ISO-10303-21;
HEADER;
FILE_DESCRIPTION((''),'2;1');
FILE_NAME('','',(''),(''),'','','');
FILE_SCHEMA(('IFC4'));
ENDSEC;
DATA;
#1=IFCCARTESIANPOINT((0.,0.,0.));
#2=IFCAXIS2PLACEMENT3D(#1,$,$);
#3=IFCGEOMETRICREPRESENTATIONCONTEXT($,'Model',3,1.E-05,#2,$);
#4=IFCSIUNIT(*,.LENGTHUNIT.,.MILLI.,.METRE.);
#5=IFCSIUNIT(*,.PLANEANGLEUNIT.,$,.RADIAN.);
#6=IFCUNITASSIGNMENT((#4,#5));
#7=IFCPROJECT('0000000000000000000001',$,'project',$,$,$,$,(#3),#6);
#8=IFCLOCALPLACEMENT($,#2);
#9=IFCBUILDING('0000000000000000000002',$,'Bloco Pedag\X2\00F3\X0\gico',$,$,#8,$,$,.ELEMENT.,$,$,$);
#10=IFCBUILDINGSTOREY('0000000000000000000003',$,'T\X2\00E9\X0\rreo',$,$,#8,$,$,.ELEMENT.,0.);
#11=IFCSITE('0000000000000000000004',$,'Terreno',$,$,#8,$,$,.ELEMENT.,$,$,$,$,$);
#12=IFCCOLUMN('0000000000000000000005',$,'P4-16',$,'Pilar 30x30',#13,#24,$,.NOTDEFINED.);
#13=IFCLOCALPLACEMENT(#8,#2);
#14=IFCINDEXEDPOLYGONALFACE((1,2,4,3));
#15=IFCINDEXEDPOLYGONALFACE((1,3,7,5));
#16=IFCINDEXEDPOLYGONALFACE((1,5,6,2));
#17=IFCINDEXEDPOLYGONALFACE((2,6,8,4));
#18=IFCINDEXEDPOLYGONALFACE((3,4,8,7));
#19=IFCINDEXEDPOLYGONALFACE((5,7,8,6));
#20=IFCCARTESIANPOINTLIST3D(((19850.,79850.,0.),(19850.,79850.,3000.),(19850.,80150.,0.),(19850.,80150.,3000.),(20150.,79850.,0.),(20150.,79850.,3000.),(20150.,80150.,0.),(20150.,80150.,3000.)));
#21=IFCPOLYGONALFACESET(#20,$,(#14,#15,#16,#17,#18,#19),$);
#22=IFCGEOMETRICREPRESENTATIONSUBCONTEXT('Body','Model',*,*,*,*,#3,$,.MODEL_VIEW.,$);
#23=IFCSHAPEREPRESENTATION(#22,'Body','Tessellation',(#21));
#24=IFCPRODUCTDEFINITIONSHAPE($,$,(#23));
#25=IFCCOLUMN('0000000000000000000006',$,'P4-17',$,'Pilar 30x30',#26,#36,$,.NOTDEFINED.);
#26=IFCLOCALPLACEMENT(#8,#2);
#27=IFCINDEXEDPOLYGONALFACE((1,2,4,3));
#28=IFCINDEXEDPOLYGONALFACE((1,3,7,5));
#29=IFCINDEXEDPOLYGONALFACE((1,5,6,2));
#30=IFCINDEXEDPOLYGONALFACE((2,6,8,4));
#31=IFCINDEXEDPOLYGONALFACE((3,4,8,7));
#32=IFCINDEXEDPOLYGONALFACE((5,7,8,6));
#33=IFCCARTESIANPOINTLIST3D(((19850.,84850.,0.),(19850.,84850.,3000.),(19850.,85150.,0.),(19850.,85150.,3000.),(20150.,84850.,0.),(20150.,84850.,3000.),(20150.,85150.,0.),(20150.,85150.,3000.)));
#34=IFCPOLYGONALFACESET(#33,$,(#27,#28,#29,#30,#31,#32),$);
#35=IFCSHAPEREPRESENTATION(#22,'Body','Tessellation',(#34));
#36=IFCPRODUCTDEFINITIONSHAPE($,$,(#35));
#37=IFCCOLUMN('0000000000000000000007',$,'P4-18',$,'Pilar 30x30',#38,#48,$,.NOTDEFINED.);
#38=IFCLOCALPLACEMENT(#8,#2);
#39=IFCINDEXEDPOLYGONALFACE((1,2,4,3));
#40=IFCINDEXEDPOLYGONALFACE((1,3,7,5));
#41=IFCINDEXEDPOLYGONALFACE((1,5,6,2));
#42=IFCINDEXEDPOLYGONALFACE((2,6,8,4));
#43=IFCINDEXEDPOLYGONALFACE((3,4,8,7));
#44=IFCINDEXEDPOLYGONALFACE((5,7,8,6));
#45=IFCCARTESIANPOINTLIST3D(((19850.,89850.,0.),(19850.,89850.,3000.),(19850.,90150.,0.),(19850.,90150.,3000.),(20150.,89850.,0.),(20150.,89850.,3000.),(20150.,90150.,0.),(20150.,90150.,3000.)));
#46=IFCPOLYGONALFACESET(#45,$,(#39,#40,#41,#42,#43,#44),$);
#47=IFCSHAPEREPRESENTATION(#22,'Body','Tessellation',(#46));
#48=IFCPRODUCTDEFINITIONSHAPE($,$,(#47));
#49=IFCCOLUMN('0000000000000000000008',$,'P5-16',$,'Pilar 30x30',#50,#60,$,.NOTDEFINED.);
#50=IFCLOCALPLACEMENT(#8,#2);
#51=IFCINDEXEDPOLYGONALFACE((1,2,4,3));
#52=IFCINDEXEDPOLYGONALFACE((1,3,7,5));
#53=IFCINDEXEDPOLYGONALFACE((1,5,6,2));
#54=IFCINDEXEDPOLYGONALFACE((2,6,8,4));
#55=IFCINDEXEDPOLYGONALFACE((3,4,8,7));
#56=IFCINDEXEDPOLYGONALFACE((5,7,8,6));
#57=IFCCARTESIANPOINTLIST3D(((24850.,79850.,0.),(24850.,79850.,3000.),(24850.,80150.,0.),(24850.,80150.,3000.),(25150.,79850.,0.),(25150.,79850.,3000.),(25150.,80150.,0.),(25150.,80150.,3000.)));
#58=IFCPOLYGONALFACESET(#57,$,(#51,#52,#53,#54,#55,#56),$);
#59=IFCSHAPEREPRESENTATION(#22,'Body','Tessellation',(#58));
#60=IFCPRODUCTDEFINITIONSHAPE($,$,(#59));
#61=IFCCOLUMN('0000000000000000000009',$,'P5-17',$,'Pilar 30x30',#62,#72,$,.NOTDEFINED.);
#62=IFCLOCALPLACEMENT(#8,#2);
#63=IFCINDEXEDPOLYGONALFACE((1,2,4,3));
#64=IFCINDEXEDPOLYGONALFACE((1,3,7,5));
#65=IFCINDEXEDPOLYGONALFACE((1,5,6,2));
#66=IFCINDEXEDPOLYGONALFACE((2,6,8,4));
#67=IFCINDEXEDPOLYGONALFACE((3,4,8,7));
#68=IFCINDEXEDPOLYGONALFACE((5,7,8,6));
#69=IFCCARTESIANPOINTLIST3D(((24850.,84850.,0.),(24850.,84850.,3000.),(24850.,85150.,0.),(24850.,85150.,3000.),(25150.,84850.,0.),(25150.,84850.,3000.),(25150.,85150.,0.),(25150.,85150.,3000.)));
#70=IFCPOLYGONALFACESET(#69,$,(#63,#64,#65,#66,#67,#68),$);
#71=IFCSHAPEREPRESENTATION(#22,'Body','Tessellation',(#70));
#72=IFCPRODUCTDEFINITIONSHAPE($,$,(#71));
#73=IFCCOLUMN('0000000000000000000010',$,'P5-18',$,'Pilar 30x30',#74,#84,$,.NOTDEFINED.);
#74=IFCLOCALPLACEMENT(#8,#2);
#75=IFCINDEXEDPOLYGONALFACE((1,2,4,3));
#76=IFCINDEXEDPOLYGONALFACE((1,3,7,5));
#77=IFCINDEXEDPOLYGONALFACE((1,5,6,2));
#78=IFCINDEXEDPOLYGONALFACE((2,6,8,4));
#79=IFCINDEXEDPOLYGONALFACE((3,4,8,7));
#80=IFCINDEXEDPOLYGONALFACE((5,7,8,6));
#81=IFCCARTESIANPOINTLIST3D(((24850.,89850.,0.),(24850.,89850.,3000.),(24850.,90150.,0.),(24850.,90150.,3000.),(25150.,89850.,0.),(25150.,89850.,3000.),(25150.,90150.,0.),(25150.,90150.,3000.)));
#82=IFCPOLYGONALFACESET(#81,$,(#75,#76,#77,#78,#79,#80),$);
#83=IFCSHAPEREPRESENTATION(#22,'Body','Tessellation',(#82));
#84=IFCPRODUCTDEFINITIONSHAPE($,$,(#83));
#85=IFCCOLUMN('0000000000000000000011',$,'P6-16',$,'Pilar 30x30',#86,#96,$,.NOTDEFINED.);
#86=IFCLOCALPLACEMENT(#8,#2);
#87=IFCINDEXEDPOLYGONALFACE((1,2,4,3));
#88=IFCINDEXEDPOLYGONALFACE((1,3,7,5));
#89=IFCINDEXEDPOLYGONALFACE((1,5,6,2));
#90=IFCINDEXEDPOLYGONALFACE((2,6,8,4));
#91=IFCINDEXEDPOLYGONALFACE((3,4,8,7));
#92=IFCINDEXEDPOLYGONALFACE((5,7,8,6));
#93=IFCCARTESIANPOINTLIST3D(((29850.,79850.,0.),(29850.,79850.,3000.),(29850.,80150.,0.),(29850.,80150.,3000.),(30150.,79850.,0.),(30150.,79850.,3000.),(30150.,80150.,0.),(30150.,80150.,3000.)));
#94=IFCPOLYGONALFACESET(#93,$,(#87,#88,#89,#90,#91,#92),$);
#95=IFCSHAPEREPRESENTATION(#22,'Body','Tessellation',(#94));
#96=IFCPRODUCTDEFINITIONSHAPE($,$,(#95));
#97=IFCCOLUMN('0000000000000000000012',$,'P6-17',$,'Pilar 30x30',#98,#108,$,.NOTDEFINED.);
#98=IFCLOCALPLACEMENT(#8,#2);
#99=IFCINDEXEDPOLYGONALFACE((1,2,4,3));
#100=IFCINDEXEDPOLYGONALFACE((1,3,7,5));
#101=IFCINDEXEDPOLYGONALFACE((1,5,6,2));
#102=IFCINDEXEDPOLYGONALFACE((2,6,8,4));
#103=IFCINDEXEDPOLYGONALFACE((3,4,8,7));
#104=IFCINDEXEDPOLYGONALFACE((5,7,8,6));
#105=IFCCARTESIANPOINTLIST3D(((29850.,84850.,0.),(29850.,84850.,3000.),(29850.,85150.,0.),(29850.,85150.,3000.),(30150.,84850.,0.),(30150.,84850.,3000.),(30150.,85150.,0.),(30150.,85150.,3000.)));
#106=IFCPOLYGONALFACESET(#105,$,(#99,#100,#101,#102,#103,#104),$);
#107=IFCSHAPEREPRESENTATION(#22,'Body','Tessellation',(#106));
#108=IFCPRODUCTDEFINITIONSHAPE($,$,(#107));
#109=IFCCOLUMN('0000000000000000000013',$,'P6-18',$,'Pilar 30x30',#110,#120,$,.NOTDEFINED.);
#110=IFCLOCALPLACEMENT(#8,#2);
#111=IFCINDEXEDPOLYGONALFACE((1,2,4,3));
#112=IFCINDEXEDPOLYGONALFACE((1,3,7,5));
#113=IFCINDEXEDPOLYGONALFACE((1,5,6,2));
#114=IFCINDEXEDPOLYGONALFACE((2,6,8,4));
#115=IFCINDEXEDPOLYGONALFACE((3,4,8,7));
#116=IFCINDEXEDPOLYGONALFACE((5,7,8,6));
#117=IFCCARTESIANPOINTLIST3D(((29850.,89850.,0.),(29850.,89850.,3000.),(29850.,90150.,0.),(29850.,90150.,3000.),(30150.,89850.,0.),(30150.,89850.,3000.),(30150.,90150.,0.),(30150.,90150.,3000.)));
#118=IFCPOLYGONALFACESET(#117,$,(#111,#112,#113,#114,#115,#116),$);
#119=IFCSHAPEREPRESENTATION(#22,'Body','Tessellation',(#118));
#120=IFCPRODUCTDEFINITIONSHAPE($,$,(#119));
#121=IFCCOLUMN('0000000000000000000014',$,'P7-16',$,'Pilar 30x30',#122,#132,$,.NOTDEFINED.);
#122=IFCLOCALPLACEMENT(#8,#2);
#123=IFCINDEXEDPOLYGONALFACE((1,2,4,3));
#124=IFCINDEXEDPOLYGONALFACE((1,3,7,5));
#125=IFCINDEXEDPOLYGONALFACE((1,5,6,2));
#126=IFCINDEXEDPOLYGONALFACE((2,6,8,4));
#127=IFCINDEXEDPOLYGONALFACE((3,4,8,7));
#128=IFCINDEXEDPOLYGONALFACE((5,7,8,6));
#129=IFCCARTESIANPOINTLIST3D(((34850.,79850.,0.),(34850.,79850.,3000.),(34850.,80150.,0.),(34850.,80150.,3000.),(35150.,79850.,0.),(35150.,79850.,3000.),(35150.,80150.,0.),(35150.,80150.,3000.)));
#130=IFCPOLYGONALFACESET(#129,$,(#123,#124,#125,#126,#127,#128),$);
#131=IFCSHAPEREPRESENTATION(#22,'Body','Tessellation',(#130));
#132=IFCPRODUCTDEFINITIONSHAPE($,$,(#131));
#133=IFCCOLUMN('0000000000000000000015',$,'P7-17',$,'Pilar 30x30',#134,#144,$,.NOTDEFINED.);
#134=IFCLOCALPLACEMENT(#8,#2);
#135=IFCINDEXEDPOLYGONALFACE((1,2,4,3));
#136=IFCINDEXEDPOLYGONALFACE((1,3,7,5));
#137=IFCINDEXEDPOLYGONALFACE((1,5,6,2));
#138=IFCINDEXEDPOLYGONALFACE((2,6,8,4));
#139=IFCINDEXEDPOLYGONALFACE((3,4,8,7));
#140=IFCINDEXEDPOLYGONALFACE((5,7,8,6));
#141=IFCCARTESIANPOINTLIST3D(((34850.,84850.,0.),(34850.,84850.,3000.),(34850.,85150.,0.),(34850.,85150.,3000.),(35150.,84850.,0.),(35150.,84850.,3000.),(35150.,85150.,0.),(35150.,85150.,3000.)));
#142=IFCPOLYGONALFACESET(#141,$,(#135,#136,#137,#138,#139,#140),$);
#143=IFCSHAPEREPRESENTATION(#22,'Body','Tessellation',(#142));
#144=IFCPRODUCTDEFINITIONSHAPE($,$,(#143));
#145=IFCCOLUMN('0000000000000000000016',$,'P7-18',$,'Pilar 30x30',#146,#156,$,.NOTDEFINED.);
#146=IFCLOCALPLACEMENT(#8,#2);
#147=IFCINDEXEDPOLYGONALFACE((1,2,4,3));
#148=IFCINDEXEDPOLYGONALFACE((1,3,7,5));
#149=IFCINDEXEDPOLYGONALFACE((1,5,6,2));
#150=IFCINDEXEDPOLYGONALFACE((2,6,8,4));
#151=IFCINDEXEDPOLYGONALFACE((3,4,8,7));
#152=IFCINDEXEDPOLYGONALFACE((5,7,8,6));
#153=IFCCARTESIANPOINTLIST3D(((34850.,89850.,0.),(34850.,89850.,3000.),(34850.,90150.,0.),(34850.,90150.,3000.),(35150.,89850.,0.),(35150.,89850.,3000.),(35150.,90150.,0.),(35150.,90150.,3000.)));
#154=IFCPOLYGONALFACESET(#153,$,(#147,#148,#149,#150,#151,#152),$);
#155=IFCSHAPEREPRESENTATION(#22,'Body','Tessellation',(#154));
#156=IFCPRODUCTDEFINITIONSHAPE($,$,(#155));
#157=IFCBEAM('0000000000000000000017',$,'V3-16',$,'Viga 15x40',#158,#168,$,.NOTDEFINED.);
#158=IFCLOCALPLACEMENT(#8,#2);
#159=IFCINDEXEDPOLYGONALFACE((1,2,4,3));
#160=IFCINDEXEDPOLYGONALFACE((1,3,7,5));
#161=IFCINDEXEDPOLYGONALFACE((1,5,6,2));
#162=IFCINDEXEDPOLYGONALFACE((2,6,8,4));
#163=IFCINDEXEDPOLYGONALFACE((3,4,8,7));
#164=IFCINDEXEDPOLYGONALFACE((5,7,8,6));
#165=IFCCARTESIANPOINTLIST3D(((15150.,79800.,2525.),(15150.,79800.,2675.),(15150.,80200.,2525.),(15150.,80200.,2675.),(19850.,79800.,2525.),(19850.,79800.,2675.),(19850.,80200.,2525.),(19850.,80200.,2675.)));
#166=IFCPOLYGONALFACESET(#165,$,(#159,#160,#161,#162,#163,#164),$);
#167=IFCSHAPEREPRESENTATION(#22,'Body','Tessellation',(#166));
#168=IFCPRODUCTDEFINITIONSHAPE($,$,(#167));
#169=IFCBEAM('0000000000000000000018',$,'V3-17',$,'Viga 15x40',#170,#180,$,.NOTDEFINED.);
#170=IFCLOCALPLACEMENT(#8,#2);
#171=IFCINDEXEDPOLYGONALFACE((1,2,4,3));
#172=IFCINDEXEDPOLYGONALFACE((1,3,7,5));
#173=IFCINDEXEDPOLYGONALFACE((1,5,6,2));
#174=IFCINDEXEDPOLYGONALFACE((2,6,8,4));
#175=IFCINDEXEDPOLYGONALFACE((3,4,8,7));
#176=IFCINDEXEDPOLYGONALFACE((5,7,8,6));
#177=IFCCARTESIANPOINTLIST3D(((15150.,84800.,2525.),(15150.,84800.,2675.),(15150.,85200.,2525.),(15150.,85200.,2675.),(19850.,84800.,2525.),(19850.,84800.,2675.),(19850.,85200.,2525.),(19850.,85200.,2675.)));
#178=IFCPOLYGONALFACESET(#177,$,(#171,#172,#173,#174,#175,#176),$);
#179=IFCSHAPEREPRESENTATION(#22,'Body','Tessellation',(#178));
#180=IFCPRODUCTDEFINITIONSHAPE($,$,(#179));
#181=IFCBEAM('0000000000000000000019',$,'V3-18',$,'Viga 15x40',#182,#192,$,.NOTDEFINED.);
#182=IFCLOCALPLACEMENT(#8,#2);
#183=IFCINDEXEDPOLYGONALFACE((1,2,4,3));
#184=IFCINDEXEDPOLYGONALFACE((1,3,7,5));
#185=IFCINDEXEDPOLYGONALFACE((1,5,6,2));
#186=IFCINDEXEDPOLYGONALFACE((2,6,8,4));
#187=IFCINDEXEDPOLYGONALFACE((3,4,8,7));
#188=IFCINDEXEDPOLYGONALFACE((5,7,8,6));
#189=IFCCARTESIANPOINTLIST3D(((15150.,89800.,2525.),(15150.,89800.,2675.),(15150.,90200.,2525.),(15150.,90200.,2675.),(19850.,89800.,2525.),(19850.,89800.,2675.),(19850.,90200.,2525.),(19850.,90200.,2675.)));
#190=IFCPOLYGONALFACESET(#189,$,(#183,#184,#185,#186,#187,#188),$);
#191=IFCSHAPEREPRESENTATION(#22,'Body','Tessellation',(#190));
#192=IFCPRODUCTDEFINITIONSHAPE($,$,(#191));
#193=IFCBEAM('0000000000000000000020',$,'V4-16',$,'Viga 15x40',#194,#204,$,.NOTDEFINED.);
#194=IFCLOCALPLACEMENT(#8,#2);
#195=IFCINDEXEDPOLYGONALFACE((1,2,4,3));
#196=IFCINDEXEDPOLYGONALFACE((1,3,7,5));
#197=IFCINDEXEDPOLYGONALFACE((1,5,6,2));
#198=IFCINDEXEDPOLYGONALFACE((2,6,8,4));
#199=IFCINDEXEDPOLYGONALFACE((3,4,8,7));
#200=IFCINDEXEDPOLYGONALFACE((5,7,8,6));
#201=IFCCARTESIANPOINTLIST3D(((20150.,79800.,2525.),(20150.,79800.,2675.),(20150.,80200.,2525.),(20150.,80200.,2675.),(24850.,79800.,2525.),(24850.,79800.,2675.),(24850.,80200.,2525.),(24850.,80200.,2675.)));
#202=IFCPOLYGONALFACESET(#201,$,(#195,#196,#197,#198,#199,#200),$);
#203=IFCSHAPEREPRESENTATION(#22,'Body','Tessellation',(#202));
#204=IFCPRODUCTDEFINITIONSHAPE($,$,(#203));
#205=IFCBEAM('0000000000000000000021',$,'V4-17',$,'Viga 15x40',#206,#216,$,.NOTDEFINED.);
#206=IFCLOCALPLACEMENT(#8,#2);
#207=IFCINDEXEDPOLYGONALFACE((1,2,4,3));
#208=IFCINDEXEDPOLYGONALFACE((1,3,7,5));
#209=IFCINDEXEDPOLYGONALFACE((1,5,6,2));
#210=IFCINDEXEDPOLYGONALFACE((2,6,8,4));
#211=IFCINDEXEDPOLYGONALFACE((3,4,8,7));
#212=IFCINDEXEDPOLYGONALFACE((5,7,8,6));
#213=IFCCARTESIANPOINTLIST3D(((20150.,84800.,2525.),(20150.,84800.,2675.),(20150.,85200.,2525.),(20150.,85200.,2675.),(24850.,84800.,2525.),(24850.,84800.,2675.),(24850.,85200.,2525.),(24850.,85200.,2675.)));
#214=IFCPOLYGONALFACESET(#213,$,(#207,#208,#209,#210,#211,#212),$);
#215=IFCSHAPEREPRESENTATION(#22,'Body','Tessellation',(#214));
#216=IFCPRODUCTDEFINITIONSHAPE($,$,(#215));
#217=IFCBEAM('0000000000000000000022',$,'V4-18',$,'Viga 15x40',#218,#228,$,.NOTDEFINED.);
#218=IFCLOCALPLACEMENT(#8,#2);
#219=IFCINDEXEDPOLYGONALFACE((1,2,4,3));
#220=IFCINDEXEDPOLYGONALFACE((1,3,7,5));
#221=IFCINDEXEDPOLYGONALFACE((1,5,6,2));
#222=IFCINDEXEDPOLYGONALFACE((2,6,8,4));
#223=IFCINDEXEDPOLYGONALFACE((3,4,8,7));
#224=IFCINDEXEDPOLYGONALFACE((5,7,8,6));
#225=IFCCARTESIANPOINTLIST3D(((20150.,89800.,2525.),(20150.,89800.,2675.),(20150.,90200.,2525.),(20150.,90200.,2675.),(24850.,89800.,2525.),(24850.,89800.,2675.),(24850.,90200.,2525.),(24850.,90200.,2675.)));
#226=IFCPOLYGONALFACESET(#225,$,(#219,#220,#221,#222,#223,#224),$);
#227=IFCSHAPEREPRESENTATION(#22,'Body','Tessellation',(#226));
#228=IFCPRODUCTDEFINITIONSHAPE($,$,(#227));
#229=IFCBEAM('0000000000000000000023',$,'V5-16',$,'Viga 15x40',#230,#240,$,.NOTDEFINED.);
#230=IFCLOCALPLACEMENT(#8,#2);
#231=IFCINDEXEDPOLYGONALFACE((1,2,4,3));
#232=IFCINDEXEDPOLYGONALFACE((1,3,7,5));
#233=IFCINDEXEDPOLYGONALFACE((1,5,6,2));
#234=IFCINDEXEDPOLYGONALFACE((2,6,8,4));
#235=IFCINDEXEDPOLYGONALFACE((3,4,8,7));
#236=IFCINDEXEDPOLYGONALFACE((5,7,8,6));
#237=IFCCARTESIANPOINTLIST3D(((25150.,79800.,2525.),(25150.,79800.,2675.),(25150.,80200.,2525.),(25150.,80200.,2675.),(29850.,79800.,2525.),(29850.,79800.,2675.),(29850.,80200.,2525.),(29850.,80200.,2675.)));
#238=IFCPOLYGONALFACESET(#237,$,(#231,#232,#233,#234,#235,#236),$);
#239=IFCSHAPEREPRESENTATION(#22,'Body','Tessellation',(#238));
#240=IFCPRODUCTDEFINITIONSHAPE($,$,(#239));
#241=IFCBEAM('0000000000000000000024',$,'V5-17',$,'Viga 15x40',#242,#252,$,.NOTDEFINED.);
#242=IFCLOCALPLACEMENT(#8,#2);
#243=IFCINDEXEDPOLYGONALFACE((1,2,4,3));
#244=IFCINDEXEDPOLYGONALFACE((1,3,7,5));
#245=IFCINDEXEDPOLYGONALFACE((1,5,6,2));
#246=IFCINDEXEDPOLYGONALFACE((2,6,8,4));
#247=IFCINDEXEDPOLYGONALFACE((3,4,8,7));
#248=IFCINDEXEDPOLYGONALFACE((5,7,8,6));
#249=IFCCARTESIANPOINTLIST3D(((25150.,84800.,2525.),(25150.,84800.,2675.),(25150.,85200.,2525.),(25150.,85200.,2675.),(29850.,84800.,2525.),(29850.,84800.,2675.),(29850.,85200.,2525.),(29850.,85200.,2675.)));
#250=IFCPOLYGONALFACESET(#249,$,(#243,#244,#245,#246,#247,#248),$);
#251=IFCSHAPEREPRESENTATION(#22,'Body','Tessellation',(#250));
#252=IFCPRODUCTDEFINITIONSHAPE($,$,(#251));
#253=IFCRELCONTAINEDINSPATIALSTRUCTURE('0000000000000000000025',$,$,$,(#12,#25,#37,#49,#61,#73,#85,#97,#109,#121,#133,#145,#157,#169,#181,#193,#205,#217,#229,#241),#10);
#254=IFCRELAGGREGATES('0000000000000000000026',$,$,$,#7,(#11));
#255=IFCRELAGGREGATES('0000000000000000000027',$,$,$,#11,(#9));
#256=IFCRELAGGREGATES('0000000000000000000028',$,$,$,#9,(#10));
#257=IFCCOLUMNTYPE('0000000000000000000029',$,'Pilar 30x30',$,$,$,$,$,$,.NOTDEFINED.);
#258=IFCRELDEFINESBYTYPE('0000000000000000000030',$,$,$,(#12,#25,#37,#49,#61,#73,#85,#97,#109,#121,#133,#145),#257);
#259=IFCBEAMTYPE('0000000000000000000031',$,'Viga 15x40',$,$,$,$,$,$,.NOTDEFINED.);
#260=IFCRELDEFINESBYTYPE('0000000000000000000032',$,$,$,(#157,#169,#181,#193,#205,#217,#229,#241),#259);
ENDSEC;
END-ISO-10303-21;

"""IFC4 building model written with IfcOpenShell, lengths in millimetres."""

from ifc_helpers import new_model, si_unit, frame, origin, origin_2d, place, context, subcontext, project, spatial, rectangle, extrude, type_object, element, save


model = new_model("IFC4")

# Units and contexts
model_context = context("Model", 3, precision=1e-05, world=origin())
body_context = subcontext(model_context, "Body", "Model", "MODEL_VIEW")
ifc_project = project(units=[si_unit("LENGTHUNIT", "METRE", prefix="MILLI"), si_unit("PLANEANGLEUNIT", "RADIAN")], contexts=[model_context])

# Site, building, storey
placement = place(None, origin())
site = spatial("IfcSite", under=ifc_project, at=placement, Name="Terreno", CompositionType="ELEMENT")
building = spatial("IfcBuilding", under=site, at=placement, Name="Bloco Pedagógico", CompositionType="ELEMENT")
storey = spatial("IfcBuildingStorey", under=building, at=placement, Name="Térreo", CompositionType="ELEMENT", Elevation=0.0)

# Columns
column_type = type_object("IfcColumnType", Name="Pilar 30x30", PredefinedType="NOTDEFINED")
for number, where, z_axis, x_axis, name in (
    (1, (20000.0, 80000.0, 0.0), (0.0, 0.0, 1.0), (1.0, 0.0, 0.0), "P4-16"),
    (2, (20000.0, 85000.0, 0.0), (0.0, 0.0, 1.0), (1.0, 0.0, 0.0), "P4-17"),
    (3, (20000.0, 90000.0, 0.0), (0.0, 0.0, 1.0), (1.0, 0.0, 0.0), "P4-18"),
    (4, (25000.0, 80000.0, 0.0), (0.0, 0.0, 1.0), (1.0, 0.0, 0.0), "P5-16"),
    (5, (25000.0, 85000.0, 0.0), (0.0, 0.0, 1.0), (1.0, 0.0, 0.0), "P5-17"),
    (6, (25000.0, 90000.0, 0.0), (0.0, 0.0, 1.0), (1.0, 0.0, 0.0), "P5-18"),
    (7, (30000.0, 80000.0, 0.0), (0.0, 0.0, 1.0), (1.0, 0.0, 0.0), "P6-16"),
    (8, (30000.0, 85000.0, 0.0), (0.0, 0.0, 1.0), (1.0, 0.0, 0.0), "P6-17"),
    (9, (30000.0, 90000.0, 0.0), (0.0, 0.0, 1.0), (1.0, 0.0, 0.0), "P6-18"),
    (10, (35000.0, 80000.0, 0.0), (0.0, 0.0, 1.0), (1.0, 0.0, 0.0), "P7-16"),
    (11, (35000.0, 85000.0, 0.0), (0.0, 0.0, 1.0), (1.0, 0.0, 0.0), "P7-17"),
    (12, (35000.0, 90000.0, 0.0), (0.0, 0.0, 1.0), (1.0, 0.0, 0.0), "P7-18"),
):
    element("IfcColumn", number, at=place(None, frame(where, z_axis=z_axis, x_axis=x_axis)), inside=storey, type_object=column_type, Name=name, ObjectType="Pilar 30x30", PredefinedType="NOTDEFINED", context=body_context, shape_type="SweptSolid", body=[
        extrude(rectangle(XDim=300.0, YDim=300.0, at=origin_2d()), None, (0.0, 0.0, 1.0), 3000.0),
    ])

# Beams
beam_type = type_object("IfcBeamType", Name="Viga 15x40", PredefinedType="NOTDEFINED")
for number, where, z_axis, x_axis, name in (
    (13, (15150.0, 80000.0, 2600.0), (1.0, 0.0, 0.0), (0.0, 1.0, 0.0), "V3-16"),
    (14, (15150.0, 85000.0, 2600.0), (1.0, 0.0, 0.0), (0.0, 1.0, 0.0), "V3-17"),
    (15, (15150.0, 90000.0, 2600.0), (1.0, 0.0, 0.0), (0.0, 1.0, 0.0), "V3-18"),
    (16, (20150.0, 80000.0, 2600.0), (1.0, 0.0, 0.0), (0.0, 1.0, 0.0), "V4-16"),
    (17, (20150.0, 85000.0, 2600.0), (1.0, 0.0, 0.0), (0.0, 1.0, 0.0), "V4-17"),
    (18, (20150.0, 90000.0, 2600.0), (1.0, 0.0, 0.0), (0.0, 1.0, 0.0), "V4-18"),
    (19, (25150.0, 80000.0, 2600.0), (1.0, 0.0, 0.0), (0.0, 1.0, 0.0), "V5-16"),
    (20, (25150.0, 85000.0, 2600.0), (1.0, 0.0, 0.0), (0.0, 1.0, 0.0), "V5-17"),
):
    element("IfcBeam", number, at=place(None, frame(where, z_axis=z_axis, x_axis=x_axis)), inside=storey, type_object=beam_type, Name=name, ObjectType="Viga 15x40", PredefinedType="NOTDEFINED", context=body_context, shape_type="SweptSolid", body=[
        extrude(rectangle(XDim=400.0, YDim=150.0, at=origin_2d()), None, (0.0, 0.0, 1.0), 4700.0),
    ])

save(model, "model.ifc")
